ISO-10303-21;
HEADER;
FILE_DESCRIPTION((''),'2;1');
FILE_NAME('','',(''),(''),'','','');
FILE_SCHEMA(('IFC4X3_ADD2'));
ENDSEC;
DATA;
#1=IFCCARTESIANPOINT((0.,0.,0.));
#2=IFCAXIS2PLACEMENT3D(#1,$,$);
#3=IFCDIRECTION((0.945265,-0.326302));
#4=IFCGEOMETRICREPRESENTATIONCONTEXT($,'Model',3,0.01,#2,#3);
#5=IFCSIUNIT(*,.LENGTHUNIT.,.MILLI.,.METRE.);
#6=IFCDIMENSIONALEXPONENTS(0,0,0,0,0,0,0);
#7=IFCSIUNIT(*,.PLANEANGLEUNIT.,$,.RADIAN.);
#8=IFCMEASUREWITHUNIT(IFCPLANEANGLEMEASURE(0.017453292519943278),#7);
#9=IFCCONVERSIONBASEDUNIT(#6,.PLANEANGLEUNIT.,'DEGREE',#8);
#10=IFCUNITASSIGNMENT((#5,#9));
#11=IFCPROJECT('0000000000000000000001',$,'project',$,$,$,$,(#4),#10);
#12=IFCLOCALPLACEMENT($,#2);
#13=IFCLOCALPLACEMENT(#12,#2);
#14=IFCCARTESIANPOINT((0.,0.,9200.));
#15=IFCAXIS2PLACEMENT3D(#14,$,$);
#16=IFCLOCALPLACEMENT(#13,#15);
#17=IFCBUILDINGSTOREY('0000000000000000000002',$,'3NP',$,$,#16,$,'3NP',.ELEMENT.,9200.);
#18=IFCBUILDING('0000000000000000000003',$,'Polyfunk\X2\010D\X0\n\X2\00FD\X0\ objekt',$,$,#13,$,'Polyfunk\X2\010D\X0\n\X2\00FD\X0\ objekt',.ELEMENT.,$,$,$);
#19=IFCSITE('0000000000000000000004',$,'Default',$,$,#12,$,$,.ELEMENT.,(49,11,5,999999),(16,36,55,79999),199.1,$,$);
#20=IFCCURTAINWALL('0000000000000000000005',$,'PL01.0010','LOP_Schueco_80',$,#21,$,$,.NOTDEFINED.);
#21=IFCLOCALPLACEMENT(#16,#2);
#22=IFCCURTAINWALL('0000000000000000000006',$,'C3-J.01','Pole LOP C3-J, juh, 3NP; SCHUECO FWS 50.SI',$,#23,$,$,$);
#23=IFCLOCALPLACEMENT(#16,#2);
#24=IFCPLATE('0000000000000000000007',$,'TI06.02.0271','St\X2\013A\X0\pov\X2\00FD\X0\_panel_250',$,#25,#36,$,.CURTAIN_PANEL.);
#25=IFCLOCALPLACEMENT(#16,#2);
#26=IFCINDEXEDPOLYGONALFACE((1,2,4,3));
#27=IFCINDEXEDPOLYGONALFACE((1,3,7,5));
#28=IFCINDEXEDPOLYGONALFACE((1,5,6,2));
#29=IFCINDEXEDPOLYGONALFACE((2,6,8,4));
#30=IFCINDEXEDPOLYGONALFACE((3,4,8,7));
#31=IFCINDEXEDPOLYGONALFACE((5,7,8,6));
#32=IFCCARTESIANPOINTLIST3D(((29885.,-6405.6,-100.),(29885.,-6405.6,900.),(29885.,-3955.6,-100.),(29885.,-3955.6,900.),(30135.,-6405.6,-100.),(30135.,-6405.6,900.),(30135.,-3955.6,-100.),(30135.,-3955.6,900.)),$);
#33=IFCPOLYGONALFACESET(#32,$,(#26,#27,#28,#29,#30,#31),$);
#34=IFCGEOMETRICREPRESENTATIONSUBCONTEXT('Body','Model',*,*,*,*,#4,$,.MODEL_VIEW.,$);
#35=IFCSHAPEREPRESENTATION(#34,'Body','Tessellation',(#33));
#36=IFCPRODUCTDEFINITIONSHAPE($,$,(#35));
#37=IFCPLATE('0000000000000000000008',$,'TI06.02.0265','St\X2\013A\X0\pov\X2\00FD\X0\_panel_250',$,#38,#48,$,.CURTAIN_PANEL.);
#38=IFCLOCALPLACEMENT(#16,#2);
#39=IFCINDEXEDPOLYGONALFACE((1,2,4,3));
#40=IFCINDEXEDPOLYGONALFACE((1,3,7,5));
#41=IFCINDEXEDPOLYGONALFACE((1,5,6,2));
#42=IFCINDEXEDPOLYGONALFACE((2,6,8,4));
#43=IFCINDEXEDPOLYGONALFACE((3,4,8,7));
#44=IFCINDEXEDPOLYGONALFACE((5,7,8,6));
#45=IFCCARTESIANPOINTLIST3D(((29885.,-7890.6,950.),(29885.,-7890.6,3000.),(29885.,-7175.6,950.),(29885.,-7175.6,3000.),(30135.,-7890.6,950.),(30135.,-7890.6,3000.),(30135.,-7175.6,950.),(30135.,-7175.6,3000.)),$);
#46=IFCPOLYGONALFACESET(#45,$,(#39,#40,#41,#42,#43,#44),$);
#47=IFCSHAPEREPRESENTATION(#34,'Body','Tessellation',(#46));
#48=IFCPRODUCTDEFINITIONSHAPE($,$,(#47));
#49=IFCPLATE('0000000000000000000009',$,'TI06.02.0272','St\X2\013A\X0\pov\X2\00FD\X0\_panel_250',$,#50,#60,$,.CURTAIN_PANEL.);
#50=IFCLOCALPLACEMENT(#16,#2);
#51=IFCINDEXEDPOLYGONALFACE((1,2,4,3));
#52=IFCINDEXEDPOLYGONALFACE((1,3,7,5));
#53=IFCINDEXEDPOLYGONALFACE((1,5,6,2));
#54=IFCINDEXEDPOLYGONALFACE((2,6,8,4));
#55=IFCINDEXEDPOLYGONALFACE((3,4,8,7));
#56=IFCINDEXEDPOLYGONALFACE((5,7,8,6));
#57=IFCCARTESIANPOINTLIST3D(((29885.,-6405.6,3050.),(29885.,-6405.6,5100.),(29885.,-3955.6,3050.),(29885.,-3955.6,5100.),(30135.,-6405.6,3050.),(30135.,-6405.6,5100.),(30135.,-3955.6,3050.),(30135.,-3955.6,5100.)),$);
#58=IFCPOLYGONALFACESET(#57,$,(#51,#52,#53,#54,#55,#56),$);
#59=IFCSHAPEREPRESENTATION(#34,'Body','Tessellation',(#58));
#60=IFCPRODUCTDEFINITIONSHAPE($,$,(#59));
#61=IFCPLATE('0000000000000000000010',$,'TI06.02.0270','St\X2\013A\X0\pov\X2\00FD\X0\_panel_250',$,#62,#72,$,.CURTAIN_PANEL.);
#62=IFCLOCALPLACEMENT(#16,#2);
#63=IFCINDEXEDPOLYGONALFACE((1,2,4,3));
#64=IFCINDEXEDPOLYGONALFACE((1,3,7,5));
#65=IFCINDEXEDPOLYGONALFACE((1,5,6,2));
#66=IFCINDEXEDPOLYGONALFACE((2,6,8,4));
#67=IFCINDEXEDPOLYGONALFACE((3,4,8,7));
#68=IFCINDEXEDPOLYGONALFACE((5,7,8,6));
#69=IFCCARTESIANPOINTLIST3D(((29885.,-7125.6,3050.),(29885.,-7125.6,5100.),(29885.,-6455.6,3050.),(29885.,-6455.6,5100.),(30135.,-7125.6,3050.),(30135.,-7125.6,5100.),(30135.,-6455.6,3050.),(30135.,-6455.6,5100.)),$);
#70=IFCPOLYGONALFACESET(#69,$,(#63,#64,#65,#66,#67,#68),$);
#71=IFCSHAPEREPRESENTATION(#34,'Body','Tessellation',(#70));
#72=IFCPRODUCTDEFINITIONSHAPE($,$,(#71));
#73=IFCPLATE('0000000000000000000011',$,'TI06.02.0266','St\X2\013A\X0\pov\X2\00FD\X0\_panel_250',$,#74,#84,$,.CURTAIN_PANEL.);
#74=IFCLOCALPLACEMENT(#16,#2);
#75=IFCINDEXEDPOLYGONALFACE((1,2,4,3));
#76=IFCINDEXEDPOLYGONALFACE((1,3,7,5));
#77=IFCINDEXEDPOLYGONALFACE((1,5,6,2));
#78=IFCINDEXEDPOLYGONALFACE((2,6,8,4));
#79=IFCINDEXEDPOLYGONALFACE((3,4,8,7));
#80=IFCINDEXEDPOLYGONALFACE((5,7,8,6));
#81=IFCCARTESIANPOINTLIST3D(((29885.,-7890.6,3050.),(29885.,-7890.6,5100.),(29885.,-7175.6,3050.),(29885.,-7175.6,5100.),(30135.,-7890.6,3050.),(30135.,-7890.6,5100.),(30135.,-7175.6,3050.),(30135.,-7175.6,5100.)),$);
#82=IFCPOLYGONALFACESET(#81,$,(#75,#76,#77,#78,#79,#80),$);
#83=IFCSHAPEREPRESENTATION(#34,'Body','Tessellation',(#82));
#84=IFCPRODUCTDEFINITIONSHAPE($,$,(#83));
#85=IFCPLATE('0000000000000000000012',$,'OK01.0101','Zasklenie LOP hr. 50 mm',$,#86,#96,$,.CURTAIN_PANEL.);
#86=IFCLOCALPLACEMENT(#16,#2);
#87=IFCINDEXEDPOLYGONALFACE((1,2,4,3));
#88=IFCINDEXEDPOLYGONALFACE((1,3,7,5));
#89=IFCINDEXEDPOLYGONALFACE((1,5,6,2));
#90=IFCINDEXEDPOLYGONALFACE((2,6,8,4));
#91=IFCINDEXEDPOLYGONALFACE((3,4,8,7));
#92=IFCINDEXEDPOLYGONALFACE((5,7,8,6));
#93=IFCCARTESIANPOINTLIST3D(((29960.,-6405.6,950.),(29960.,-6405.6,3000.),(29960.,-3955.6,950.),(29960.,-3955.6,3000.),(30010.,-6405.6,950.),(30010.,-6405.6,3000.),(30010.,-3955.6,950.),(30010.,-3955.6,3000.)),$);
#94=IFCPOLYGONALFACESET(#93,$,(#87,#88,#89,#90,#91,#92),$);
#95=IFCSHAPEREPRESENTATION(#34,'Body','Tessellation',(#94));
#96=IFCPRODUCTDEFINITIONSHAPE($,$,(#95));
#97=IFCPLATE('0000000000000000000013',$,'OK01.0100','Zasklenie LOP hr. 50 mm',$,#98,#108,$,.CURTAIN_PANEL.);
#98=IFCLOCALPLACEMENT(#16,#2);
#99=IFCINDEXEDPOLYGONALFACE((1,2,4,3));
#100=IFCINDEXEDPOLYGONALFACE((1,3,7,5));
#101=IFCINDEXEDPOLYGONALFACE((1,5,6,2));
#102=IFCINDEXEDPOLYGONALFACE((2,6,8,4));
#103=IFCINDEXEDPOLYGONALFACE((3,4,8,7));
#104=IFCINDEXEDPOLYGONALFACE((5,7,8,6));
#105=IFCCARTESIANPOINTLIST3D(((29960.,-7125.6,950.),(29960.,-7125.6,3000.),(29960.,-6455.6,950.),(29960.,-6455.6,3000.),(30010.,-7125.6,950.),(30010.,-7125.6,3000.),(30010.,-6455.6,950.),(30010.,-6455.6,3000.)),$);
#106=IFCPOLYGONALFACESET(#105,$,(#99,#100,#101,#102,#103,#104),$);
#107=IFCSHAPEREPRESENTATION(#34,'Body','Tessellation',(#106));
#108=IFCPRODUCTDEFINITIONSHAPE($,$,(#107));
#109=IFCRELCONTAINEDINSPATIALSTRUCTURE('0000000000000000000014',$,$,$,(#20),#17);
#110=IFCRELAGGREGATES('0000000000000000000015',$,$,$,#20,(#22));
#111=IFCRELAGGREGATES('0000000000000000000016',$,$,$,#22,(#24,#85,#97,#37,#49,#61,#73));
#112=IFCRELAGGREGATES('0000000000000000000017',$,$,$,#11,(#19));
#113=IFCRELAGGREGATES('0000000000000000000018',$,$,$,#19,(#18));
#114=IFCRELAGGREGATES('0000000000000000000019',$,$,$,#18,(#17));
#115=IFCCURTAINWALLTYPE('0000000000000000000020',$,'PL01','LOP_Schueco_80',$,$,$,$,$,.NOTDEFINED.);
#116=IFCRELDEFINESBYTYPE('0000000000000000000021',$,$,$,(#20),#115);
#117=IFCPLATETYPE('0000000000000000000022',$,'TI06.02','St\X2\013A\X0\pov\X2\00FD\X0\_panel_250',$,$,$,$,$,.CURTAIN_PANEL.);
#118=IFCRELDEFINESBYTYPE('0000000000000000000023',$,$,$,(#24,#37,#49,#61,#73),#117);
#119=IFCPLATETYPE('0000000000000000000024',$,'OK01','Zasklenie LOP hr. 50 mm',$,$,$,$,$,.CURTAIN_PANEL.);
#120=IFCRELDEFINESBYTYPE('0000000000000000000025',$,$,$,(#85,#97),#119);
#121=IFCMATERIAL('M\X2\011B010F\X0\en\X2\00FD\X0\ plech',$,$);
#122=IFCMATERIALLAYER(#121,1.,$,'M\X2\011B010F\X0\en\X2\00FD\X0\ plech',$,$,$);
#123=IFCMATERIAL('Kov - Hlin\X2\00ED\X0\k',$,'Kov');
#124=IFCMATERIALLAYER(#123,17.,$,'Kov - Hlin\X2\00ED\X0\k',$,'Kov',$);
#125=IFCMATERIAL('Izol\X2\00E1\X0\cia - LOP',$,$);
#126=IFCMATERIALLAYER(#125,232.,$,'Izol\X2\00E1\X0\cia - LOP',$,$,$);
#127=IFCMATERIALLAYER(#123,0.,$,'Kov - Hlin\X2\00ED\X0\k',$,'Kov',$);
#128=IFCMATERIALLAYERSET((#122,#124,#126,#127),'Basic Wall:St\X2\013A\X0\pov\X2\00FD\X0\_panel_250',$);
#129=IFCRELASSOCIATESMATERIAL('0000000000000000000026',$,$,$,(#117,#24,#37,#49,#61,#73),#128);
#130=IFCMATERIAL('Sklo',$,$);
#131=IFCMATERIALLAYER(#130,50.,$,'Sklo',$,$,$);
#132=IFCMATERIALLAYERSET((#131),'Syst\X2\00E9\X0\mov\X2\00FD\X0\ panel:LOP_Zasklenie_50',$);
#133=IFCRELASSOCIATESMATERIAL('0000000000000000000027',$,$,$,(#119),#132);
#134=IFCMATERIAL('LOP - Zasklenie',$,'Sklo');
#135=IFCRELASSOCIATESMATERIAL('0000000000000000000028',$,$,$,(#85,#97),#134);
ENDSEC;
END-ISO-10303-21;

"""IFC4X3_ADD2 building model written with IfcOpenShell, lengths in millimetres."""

from ifc_helpers import new_model, entity, si_unit, converted_unit, direction, frame, frame_2d, origin, origin_2d_with_axis, place, context, subcontext, project, spatial, rectangle, extrude, source, transform, mapped, material, layer, layer_set, layer_usage, type_object, type_shapes, element, aggregate, save


model = new_model("IFC4X3_ADD2")

# Units and contexts
model_context = context("Model", 3, precision=0.01, world=origin(), true_north=direction((0.945265, -0.326302)))
body_context = subcontext(model_context, "Body", "Model", "MODEL_VIEW")
ifc_project = project(units=[si_unit("LENGTHUNIT", "METRE", prefix="MILLI"), converted_unit("PLANEANGLEUNIT", "DEGREE", entity("IfcPlaneAngleMeasure", 0.017453292519943278), si_unit("PLANEANGLEUNIT", "RADIAN"), dimensions=[0, 0, 0, 0, 0, 0, 0])], contexts=[model_context])

# Site, building, storey
site_placement = place(None, origin())
site = spatial("IfcSite", under=ifc_project, at=site_placement, Name="Default", CompositionType="ELEMENT", RefLatitude=(49, 11, 5, 999999), RefLongitude=(16, 36, 55, 79999), RefElevation=199.1)
building_placement = place(site_placement, origin())
building = spatial("IfcBuilding", under=site, at=building_placement, Name="Polyfunkčný objekt", LongName="Polyfunkčný objekt", CompositionType="ELEMENT")
storey_placement = place(building_placement, frame((0.0, 0.0, 9200.0)))
storey = spatial("IfcBuildingStorey", under=building, at=storey_placement, Name="3NP", LongName="3NP", CompositionType="ELEMENT", Elevation=9200.0)

# Curtain walls, plates
curtain_wall_type = type_object("IfcCurtainWallType", Name="PL01", Description="LOP_Schueco_80", PredefinedType="NOTDEFINED")
curtain_wall_1_placement = place(storey_placement, frame((0.0, 0.0, -9200.0)))
curtain_wall_1 = element("IfcCurtainWall", 1, at=curtain_wall_1_placement, inside=storey, type_object=curtain_wall_type, Name="PL01.0010", Description="LOP_Schueco_80", PredefinedType="NOTDEFINED")
curtain_wall_2 = element("IfcCurtainWall", 2, Name="C3-J.01", Description="Pole LOP C3-J, juh, 3NP; SCHUECO FWS 50.SI")
aggregate(curtain_wall_1, [curtain_wall_2])
ifc_material_1 = material(Name="Měďený plech")
ifc_layer_1 = layer(ifc_material_1, 1.0, Name="Měďený plech")
ifc_material_2 = material(Name="Kov - Hliník", Category="Kov")
ifc_layer_2 = layer(ifc_material_2, 17.0, Name="Kov - Hliník", Category="Kov")
ifc_material_3 = material(Name="Izolácia - LOP")
ifc_layer_3 = layer(ifc_material_3, 232.0, Name="Izolácia - LOP")
ifc_layer_4 = layer(ifc_material_2, 0.0, Name="Kov - Hliník", Category="Kov")
ifc_layer_set_1 = layer_set([ifc_layer_1, ifc_layer_2, ifc_layer_3, ifc_layer_4], Name="Basic Wall:Stĺpový_panel_250")
ifc_layer_usage_1 = layer_usage(ifc_layer_set_1, "AXIS2", "POSITIVE", -125.0)
plate_type_1 = type_object("IfcPlateType", Name="TI06.02", Description="Stĺpový_panel_250", PredefinedType="CURTAIN_PANEL", material=ifc_layer_set_1)
plate_1_placement = place(storey_placement, frame((30010.0, -3955.6, -100.0), z_axis=(0.0, 0.0, 1.0), x_axis=(0.0, -1.0, 0.0)))
plate_1 = element("IfcPlate", 3, at=plate_1_placement, type_object=plate_type_1, material=ifc_layer_usage_1, Name="TI06.02.0271", Description="Stĺpový_panel_250", PredefinedType="CURTAIN_PANEL", context=body_context, shape_type="SweptSolid", body=[
    extrude(rectangle(XDim=250.0, YDim=2450.0, at=frame_2d((0.0, 0.0), x_axis=(1.0, 0.0))), frame((1225.0, 0.0, 0.0), z_axis=(0.0, 0.0, 1.0), x_axis=(0.0, 1.0, 0.0)), (0.0, 0.0, 1.0), 1000.0),
])
ifc_layer_usage_2 = layer_usage(ifc_layer_set_1, "AXIS2", "POSITIVE", -125.0)
plate_2_placement = place(storey_placement, frame((30010.0, -7175.6, 950.0), z_axis=(0.0, 0.0, 1.0), x_axis=(0.0, -1.0, 0.0)))
plate_2 = element("IfcPlate", 4, at=plate_2_placement, type_object=plate_type_1, material=ifc_layer_usage_2, Name="TI06.02.0265", Description="Stĺpový_panel_250", PredefinedType="CURTAIN_PANEL", context=body_context, shape_type="SweptSolid", body=[
    extrude(rectangle(XDim=250.0, YDim=715.0, at=frame_2d((0.0, 0.0), x_axis=(1.0, 0.0))), frame((357.5, 0.0, 0.0), z_axis=(0.0, 0.0, 1.0), x_axis=(0.0, 1.0, 0.0)), (0.0, 0.0, 1.0), 2050.0),
])
ifc_layer_usage_3 = layer_usage(ifc_layer_set_1, "AXIS2", "POSITIVE", -125.0)
plate_3_placement = place(storey_placement, frame((30010.0, -3955.6, 3050.0), z_axis=(0.0, 0.0, 1.0), x_axis=(0.0, -1.0, 0.0)))
plate_3 = element("IfcPlate", 5, at=plate_3_placement, type_object=plate_type_1, material=ifc_layer_usage_3, Name="TI06.02.0272", Description="Stĺpový_panel_250", PredefinedType="CURTAIN_PANEL", context=body_context, shape_type="SweptSolid", body=[
    extrude(rectangle(XDim=250.0, YDim=2450.0, at=frame_2d((0.0, 0.0), x_axis=(1.0, 0.0))), frame((1225.0, 0.0, 0.0), z_axis=(0.0, 0.0, 1.0), x_axis=(0.0, 1.0, 0.0)), (0.0, 0.0, 1.0), 2050.0),
])
ifc_layer_usage_4 = layer_usage(ifc_layer_set_1, "AXIS2", "POSITIVE", -125.0)
plate_4_placement = place(storey_placement, frame((30010.0, -6455.6, 3050.0), z_axis=(0.0, 0.0, 1.0), x_axis=(0.0, -1.0, 0.0)))
plate_4 = element("IfcPlate", 6, at=plate_4_placement, type_object=plate_type_1, material=ifc_layer_usage_4, Name="TI06.02.0270", Description="Stĺpový_panel_250", PredefinedType="CURTAIN_PANEL", context=body_context, shape_type="SweptSolid", body=[
    extrude(rectangle(XDim=250.0, YDim=670.0, at=frame_2d((0.0, 0.0), x_axis=(1.0, 0.0))), frame((335.0, 0.0, 0.0), z_axis=(0.0, 0.0, 1.0), x_axis=(0.0, 1.0, 0.0)), (0.0, 0.0, 1.0), 2050.0),
])
ifc_layer_usage_5 = layer_usage(ifc_layer_set_1, "AXIS2", "POSITIVE", -125.0)
plate_5_placement = place(storey_placement, frame((30010.0, -7175.6, 3050.0), z_axis=(0.0, 0.0, 1.0), x_axis=(0.0, -1.0, 0.0)))
plate_5 = element("IfcPlate", 7, at=plate_5_placement, type_object=plate_type_1, material=ifc_layer_usage_5, Name="TI06.02.0266", Description="Stĺpový_panel_250", PredefinedType="CURTAIN_PANEL", context=body_context, shape_type="SweptSolid", body=[
    extrude(rectangle(XDim=250.0, YDim=715.0, at=frame_2d((0.0, 0.0), x_axis=(1.0, 0.0))), frame((357.5, 0.0, 0.0), z_axis=(0.0, 0.0, 1.0), x_axis=(0.0, 1.0, 0.0)), (0.0, 0.0, 1.0), 2050.0),
])
ifc_material_4 = material(Name="LOP - Zasklenie", Category="Sklo")
ifc_material_5 = material(Name="Sklo")
ifc_layer_5 = layer(ifc_material_5, 50.0, Name="Sklo")
ifc_layer_set_2 = layer_set([ifc_layer_5], Name="Systémový panel:LOP_Zasklenie_50")
plate_type_2 = type_object("IfcPlateType", Name="OK01", Description="Zasklenie LOP hr. 50 mm", PredefinedType="CURTAIN_PANEL", material=ifc_layer_set_2)
shared_shape_1 = source(origin(), body_context, "Body", "SweptSolid", [
    extrude(rectangle(XDim=50.0, YDim=2450.0, at=origin_2d_with_axis()), frame((0.0, -25.0, 0.0), z_axis=(0.0, 0.0, 1.0), x_axis=(0.0, 1.0, 0.0)), (0.0, 0.0, 1.0), 2050.0),
])
plate_6_placement = place(curtain_wall_1_placement, frame((30010.0, -5180.6, 10150.0), z_axis=(0.0, 0.0, 1.0), x_axis=(0.0, -1.0, 0.0)))
plate_6 = element("IfcPlate", 8, at=plate_6_placement, type_object=plate_type_2, material=ifc_material_4, Name="OK01.0101", Description="Zasklenie LOP hr. 50 mm", PredefinedType="CURTAIN_PANEL", context=body_context, shape_type="MappedRepresentation", body=[
    mapped(shared_shape_1, transform((0.0, 0.0, 0.0), scale=1.0)),
])
shared_shape_2 = source(origin(), body_context, "Body", "SweptSolid", [
    extrude(rectangle(XDim=50.0, YDim=670.0, at=origin_2d_with_axis()), frame((0.0, -25.0, 0.0), z_axis=(0.0, 0.0, 1.0), x_axis=(0.0, 1.0, 0.0)), (0.0, 0.0, 1.0), 2050.0),
])
type_shapes(plate_type_2, [shared_shape_1, shared_shape_2])
plate_7_placement = place(curtain_wall_1_placement, frame((30010.0, -6790.6, 10150.0), z_axis=(0.0, 0.0, 1.0), x_axis=(0.0, -1.0, 0.0)))
plate_7 = element("IfcPlate", 9, at=plate_7_placement, type_object=plate_type_2, material=ifc_material_4, Name="OK01.0100", Description="Zasklenie LOP hr. 50 mm", PredefinedType="CURTAIN_PANEL", context=body_context, shape_type="MappedRepresentation", body=[
    mapped(shared_shape_2, transform((0.0, 0.0, 0.0), scale=1.0)),
])
aggregate(curtain_wall_2, [plate_1, plate_6, plate_7, plate_2, plate_3, plate_4, plate_5])

save(model, "model.ifc")
